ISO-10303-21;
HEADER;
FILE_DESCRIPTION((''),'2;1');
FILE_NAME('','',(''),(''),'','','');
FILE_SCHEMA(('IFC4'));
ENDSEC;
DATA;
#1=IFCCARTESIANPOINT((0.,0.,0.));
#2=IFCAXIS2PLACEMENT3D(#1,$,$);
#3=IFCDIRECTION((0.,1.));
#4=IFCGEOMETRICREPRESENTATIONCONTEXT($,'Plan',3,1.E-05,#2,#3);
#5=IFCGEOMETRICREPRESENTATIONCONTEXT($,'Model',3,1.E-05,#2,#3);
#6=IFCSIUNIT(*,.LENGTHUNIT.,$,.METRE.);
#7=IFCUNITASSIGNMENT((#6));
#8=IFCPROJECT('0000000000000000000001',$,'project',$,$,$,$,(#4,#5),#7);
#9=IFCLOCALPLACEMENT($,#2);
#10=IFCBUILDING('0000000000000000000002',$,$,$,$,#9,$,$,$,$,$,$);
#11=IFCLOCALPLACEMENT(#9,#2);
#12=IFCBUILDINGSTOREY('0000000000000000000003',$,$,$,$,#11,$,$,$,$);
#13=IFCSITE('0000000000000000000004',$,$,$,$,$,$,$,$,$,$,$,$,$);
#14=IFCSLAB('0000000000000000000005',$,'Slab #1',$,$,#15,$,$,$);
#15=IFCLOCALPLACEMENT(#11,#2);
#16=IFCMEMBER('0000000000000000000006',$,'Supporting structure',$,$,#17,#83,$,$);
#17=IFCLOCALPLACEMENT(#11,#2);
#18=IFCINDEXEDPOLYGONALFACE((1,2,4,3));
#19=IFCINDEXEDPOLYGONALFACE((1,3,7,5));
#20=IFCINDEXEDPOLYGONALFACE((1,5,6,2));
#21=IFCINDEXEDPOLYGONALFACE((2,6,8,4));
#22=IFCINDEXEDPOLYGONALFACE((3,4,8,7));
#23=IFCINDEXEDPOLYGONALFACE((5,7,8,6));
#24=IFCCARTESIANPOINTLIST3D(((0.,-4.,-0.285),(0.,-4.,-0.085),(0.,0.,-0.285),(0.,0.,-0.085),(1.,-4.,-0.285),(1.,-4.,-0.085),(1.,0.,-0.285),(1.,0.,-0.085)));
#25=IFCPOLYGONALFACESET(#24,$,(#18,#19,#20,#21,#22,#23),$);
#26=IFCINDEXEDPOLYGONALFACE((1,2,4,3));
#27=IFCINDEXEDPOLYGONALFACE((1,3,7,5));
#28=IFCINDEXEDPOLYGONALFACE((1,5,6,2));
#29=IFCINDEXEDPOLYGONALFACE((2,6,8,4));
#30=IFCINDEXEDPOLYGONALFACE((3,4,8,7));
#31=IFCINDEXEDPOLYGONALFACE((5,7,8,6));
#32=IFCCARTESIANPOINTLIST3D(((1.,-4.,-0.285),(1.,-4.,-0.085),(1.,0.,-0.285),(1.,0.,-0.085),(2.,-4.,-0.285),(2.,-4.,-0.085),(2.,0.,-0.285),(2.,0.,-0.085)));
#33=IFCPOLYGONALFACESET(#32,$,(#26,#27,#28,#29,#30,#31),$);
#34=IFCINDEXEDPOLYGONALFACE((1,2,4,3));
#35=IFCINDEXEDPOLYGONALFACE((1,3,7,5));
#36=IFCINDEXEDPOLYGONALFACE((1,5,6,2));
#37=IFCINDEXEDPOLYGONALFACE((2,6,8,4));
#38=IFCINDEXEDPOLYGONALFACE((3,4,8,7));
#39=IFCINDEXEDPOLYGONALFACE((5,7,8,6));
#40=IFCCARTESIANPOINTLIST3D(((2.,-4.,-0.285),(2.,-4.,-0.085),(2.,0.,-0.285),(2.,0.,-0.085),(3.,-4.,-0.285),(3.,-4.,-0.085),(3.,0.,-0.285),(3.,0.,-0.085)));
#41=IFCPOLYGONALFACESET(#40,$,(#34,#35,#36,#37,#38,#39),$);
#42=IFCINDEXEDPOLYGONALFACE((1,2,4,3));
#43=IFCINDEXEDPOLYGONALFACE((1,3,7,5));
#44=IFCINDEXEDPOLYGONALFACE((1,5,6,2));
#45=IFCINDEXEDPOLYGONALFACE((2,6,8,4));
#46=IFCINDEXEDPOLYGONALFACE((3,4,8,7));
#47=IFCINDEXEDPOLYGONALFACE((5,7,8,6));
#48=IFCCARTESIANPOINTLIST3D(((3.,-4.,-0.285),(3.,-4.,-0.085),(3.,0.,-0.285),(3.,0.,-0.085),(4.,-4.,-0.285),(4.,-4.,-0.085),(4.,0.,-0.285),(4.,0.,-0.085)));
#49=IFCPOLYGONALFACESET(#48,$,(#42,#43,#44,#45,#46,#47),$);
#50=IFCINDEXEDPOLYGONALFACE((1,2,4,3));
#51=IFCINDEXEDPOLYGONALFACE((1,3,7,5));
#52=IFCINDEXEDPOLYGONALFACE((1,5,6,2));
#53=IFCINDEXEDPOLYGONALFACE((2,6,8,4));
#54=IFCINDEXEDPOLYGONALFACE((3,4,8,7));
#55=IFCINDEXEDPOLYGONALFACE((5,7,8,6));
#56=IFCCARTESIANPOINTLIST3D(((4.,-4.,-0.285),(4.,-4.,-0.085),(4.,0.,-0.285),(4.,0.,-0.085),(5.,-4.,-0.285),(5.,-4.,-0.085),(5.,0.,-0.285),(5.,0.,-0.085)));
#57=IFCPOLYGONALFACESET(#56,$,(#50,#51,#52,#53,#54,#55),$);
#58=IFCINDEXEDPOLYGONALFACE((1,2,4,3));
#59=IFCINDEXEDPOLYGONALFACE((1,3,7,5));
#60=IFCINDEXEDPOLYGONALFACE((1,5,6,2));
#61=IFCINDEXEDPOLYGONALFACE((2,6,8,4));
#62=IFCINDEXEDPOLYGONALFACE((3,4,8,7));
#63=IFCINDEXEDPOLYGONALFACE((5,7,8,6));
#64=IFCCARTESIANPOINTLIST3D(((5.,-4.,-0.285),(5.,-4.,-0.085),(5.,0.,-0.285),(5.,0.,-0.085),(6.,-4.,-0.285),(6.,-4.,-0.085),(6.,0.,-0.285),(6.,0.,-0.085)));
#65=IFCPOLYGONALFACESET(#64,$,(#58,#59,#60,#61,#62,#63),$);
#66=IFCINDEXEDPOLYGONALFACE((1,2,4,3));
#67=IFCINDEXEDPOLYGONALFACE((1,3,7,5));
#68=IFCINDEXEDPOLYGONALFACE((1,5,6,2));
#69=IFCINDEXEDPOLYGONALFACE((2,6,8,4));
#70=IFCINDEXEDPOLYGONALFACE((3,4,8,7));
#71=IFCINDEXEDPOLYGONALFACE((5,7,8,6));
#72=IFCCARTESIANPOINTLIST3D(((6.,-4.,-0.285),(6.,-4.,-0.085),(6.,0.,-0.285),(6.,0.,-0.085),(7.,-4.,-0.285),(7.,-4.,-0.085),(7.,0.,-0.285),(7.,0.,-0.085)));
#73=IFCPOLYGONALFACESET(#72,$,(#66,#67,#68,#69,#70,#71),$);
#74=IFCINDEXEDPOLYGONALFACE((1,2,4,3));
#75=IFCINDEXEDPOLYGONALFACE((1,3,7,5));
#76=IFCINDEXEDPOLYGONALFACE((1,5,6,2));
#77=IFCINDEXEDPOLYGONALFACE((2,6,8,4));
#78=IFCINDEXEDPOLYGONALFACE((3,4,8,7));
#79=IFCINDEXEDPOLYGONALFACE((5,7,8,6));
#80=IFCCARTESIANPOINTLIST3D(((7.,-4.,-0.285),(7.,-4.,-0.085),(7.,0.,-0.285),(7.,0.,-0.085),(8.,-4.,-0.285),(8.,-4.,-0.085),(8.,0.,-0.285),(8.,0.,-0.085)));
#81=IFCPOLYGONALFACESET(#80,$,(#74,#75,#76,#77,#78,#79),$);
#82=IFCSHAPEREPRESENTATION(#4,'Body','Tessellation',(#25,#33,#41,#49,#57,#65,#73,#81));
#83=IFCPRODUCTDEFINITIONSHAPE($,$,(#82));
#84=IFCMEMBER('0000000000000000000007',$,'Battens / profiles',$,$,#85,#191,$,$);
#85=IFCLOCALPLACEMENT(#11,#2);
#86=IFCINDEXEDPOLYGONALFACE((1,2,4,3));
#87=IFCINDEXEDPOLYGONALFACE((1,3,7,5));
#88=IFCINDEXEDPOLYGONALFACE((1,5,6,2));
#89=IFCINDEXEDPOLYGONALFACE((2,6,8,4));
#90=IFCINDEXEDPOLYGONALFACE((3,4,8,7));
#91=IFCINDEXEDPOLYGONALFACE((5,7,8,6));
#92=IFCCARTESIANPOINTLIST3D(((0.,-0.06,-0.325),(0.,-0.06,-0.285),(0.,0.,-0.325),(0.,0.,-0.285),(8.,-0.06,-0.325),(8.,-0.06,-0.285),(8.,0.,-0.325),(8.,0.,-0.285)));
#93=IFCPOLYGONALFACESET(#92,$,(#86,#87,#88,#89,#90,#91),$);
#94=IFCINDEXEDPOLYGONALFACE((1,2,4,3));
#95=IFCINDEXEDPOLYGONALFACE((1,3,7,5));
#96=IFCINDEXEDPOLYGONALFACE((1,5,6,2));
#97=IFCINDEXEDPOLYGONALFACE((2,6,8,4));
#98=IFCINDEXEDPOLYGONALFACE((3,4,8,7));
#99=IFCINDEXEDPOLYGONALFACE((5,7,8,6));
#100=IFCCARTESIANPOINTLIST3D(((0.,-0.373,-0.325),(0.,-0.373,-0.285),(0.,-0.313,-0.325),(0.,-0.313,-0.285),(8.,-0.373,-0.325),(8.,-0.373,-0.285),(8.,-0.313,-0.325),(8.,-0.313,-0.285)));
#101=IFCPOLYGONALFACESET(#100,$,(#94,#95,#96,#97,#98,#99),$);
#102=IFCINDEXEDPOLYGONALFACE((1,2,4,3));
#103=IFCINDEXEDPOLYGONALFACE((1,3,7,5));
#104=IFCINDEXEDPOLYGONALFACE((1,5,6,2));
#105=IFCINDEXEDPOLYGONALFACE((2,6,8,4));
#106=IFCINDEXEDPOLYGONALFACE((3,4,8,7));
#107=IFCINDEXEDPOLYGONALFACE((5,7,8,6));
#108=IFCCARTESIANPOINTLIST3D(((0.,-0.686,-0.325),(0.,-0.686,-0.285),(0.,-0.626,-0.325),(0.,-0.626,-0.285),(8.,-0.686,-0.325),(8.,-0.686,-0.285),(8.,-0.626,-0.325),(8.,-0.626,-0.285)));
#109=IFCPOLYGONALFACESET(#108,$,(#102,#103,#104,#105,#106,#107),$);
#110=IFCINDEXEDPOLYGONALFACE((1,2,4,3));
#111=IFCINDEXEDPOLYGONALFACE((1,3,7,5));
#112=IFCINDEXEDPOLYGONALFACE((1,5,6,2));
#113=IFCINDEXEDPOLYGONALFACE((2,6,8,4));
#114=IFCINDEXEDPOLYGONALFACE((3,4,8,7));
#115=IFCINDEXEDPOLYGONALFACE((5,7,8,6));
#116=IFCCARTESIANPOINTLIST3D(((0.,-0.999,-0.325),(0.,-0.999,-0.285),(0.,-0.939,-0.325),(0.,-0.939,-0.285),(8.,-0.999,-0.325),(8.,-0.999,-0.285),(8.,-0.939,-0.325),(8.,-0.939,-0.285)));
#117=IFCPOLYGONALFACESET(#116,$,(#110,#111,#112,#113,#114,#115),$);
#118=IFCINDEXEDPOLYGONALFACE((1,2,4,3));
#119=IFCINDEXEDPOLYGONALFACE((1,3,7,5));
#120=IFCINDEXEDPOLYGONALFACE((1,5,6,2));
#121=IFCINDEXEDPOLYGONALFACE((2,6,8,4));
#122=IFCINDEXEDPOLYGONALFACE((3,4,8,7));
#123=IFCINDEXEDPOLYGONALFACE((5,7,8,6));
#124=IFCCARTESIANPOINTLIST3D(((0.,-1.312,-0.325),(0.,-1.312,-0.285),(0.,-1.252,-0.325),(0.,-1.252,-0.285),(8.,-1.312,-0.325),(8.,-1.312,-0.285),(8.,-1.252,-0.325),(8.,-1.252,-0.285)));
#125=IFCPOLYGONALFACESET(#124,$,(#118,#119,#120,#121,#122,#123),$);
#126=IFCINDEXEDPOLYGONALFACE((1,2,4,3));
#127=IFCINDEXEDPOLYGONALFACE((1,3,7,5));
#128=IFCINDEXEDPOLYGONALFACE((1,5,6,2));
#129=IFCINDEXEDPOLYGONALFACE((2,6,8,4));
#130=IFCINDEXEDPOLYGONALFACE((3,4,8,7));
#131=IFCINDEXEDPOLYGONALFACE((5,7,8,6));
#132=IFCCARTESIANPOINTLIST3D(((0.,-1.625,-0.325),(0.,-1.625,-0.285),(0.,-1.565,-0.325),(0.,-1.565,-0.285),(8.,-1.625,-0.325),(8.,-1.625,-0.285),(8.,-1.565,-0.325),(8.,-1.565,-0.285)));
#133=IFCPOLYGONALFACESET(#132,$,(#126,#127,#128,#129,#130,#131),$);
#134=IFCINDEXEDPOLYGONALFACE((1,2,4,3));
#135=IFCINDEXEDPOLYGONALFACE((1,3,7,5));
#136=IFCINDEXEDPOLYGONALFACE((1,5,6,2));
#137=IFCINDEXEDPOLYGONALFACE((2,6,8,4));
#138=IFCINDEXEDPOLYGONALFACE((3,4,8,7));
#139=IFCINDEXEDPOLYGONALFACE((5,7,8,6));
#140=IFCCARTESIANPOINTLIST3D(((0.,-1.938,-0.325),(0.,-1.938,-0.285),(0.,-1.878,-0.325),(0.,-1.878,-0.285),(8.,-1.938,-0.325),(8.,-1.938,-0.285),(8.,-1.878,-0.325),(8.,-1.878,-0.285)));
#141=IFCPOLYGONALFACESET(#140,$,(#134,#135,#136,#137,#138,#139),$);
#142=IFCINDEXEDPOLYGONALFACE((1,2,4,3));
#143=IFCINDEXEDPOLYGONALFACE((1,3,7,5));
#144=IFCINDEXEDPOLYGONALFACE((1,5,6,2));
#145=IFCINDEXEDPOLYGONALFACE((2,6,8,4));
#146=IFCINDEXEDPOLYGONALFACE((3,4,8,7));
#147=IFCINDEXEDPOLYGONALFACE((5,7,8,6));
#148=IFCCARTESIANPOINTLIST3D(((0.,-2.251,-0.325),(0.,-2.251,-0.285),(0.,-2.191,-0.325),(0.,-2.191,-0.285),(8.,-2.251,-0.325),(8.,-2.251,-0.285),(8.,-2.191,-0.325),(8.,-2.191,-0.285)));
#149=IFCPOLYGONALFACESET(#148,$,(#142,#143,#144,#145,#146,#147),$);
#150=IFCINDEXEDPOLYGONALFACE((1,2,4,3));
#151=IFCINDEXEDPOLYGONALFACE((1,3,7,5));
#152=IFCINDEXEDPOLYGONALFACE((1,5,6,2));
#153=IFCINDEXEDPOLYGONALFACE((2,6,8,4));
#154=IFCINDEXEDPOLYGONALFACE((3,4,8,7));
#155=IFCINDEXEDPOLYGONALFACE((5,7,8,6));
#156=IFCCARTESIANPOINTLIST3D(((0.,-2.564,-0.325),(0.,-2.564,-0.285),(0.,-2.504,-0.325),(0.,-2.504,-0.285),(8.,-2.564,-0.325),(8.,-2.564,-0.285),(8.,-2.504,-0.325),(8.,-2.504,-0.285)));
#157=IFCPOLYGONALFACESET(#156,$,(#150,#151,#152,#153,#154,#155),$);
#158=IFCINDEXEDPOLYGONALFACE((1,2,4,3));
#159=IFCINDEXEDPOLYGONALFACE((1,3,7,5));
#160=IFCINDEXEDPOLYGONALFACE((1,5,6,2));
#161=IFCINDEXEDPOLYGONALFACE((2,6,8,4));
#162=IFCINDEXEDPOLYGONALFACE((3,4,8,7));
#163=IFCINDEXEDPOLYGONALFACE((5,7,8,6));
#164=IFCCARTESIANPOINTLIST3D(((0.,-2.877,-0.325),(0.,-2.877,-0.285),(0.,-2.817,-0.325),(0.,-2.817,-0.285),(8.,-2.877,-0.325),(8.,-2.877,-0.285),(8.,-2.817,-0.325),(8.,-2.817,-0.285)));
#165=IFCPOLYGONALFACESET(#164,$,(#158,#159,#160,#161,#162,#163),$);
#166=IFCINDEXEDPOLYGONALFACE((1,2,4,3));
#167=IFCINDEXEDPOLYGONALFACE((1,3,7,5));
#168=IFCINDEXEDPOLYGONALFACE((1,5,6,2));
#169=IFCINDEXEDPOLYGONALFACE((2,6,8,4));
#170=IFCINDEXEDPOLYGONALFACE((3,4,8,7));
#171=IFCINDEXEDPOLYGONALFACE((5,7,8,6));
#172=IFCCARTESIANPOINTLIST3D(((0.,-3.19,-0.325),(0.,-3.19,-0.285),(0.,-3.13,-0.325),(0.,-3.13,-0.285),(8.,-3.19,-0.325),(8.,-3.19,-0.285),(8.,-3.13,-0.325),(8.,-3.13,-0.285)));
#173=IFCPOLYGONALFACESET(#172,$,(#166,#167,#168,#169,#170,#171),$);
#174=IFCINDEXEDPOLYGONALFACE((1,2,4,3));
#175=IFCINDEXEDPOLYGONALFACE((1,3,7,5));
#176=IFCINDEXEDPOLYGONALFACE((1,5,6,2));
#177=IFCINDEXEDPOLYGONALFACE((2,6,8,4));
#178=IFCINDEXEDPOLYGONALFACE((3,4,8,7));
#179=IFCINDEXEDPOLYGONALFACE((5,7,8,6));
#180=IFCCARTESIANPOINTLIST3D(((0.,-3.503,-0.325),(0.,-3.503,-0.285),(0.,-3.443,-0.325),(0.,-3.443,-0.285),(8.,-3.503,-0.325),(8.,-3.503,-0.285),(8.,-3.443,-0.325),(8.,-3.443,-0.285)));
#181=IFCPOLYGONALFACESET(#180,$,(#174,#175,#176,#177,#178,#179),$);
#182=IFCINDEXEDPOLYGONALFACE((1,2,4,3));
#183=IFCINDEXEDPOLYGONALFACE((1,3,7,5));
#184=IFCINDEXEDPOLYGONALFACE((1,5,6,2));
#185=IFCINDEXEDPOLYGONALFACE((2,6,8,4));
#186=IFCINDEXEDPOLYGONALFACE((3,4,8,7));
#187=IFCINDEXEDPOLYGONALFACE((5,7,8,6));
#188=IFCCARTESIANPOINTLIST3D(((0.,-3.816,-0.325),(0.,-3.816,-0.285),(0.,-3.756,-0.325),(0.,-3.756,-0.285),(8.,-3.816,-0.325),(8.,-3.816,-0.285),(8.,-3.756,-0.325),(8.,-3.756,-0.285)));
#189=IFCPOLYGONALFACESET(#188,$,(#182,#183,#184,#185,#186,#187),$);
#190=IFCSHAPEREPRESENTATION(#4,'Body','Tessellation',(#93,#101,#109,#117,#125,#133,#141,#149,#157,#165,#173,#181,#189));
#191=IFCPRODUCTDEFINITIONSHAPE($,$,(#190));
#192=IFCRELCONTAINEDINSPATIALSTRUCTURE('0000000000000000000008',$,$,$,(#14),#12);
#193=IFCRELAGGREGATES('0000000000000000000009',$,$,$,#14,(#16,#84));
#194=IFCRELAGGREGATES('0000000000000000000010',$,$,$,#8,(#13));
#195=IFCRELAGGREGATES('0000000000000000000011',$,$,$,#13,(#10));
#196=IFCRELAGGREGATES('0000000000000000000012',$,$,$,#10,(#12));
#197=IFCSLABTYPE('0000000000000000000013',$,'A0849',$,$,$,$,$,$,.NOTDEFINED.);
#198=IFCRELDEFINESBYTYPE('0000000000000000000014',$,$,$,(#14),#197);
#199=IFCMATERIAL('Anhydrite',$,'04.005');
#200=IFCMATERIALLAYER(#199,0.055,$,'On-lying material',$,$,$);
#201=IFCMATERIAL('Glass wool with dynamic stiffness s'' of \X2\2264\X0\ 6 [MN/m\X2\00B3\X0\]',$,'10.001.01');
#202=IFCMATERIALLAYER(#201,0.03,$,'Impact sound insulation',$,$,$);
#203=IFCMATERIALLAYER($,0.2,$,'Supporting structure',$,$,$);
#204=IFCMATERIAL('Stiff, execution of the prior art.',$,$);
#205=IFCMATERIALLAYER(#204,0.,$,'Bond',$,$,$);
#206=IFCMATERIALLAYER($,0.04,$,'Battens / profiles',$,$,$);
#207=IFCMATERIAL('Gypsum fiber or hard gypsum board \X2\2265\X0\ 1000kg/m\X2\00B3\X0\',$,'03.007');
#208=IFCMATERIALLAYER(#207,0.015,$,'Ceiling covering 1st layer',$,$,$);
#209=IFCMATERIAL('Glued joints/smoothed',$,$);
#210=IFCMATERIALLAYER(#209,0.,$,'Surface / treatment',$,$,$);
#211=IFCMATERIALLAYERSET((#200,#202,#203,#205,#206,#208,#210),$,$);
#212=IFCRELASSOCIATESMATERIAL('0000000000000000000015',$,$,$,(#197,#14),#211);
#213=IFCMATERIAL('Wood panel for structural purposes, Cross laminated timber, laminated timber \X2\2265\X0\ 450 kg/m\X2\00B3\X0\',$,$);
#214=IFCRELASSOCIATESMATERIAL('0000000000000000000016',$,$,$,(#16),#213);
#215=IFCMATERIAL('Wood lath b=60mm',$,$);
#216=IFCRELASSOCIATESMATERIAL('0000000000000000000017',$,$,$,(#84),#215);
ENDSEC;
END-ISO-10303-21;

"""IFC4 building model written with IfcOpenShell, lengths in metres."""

from ifc_helpers import new_model, si_unit, direction, frame, frame_2d, origin, place, context, project, spatial, rectangle, extrude, material, layer, layer_set, type_object, element, aggregate, save


model = new_model("IFC4")

# Units and contexts
plan_context = context("Plan", 3, precision=1e-05, world=origin(), true_north=direction((0.0, 1.0)))
model_context = context("Model", 3, precision=1e-05, world=origin(), true_north=direction((0.0, 1.0)))
ifc_project = project(units=[si_unit("LENGTHUNIT", "METRE")], contexts=[plan_context, model_context])

# Site, building, storey
site = spatial("IfcSite", under=ifc_project)
building_placement = place(None, origin())
building = spatial("IfcBuilding", under=site, at=building_placement)
storey_placement = place(building_placement, origin())
storey = spatial("IfcBuildingStorey", under=building, at=storey_placement)

# Slab, members
ifc_material_1 = material(Name="Anhydrite", Category="04.005")
ifc_layer_1 = layer(ifc_material_1, 0.055, Name="On-lying material")
ifc_material_2 = material(Name="Glass wool with dynamic stiffness s' of ≤ 6 [MN/m³]", Category="10.001.01")
ifc_layer_2 = layer(ifc_material_2, 0.03, Name="Impact sound insulation")
ifc_layer_3 = layer(None, 0.2, Name="Supporting structure")
ifc_material_3 = material(Name="Stiff, execution of the prior art.")
ifc_layer_4 = layer(ifc_material_3, 0.0, Name="Bond")
ifc_layer_5 = layer(None, 0.04, Name="Battens / profiles")
ifc_material_4 = material(Name="Gypsum fiber or hard gypsum board ≥ 1000kg/m³", Category="03.007")
ifc_layer_6 = layer(ifc_material_4, 0.015, Name="Ceiling covering 1st layer")
ifc_material_5 = material(Name="Glued joints/smoothed")
ifc_layer_7 = layer(ifc_material_5, 0.0, Name="Surface / treatment")
ifc_layer_set = layer_set([ifc_layer_1, ifc_layer_2, ifc_layer_3, ifc_layer_4, ifc_layer_5, ifc_layer_6, ifc_layer_7])
slab_type = type_object("IfcSlabType", Name="A0849", PredefinedType="NOTDEFINED", material=ifc_layer_set)
slab_placement = place(None, frame((0.0, 0.0, 0.0), z_axis=(0.0, 0.0, -1.0), x_axis=(1.0, 0.0, 0.0)))
slab = element("IfcSlab", 1, at=slab_placement, inside=storey, type_object=slab_type, material=ifc_layer_set, Name="Slab #1")
ifc_material_6 = material(Name="Wood panel for structural purposes, Cross laminated timber, laminated timber ≥ 450 kg/m³")
member_1_placement = place(slab_placement, origin())
member_1 = element("IfcMember", 2, at=member_1_placement, material=ifc_material_6, Name="Supporting structure", context=plan_context, shape_type="SweptSolid", body=[
    extrude(rectangle(XDim=1.0, YDim=0.2, at=frame_2d((0.5, 0.1), x_axis=(1.0, 0.0))), frame((0.0, 4.0, 0.085), z_axis=(0.0, -1.0, 0.0), x_axis=(1.0, 0.0, 0.0)), (0.0, 0.0, 1.0), 4.0),
    extrude(rectangle(XDim=1.0, YDim=0.2, at=frame_2d((0.5, 0.1), x_axis=(1.0, 0.0))), frame((1.0, 4.0, 0.085), z_axis=(0.0, -1.0, 0.0), x_axis=(1.0, 0.0, 0.0)), (0.0, 0.0, 1.0), 4.0),
    extrude(rectangle(XDim=1.0, YDim=0.2, at=frame_2d((0.5, 0.1), x_axis=(1.0, 0.0))), frame((2.0, 4.0, 0.085), z_axis=(0.0, -1.0, 0.0), x_axis=(1.0, 0.0, 0.0)), (0.0, 0.0, 1.0), 4.0),
    extrude(rectangle(XDim=1.0, YDim=0.2, at=frame_2d((0.5, 0.1), x_axis=(1.0, 0.0))), frame((3.0, 4.0, 0.085), z_axis=(0.0, -1.0, 0.0), x_axis=(1.0, 0.0, 0.0)), (0.0, 0.0, 1.0), 4.0),
    extrude(rectangle(XDim=1.0, YDim=0.2, at=frame_2d((0.5, 0.1), x_axis=(1.0, 0.0))), frame((4.0, 4.0, 0.085), z_axis=(0.0, -1.0, 0.0), x_axis=(1.0, 0.0, 0.0)), (0.0, 0.0, 1.0), 4.0),
    extrude(rectangle(XDim=1.0, YDim=0.2, at=frame_2d((0.5, 0.1), x_axis=(1.0, 0.0))), frame((5.0, 4.0, 0.085), z_axis=(0.0, -1.0, 0.0), x_axis=(1.0, 0.0, 0.0)), (0.0, 0.0, 1.0), 4.0),
    extrude(rectangle(XDim=1.0, YDim=0.2, at=frame_2d((0.5, 0.1), x_axis=(1.0, 0.0))), frame((6.0, 4.0, 0.085), z_axis=(0.0, -1.0, 0.0), x_axis=(1.0, 0.0, 0.0)), (0.0, 0.0, 1.0), 4.0),
    extrude(rectangle(XDim=1.0, YDim=0.2, at=frame_2d((0.5, 0.1), x_axis=(1.0, 0.0))), frame((7.0, 4.0, 0.085), z_axis=(0.0, -1.0, 0.0), x_axis=(1.0, 0.0, 0.0)), (0.0, 0.0, 1.0), 4.0),
])
ifc_material_7 = material(Name="Wood lath b=60mm")
member_2_placement = place(slab_placement, origin())
member_2 = element("IfcMember", 3, at=member_2_placement, material=ifc_material_7, Name="Battens / profiles", context=plan_context, shape_type="SweptSolid", body=[
    extrude(rectangle(XDim=0.06, YDim=0.04, at=frame_2d((0.03, 0.02), x_axis=(1.0, 0.0))), frame((0.0, 0.0, 0.285), z_axis=(1.0, 0.0, 0.0), x_axis=(0.0, 1.0, 0.0)), (0.0, 0.0, 1.0), 8.0),
    extrude(rectangle(XDim=0.06, YDim=0.04, at=frame_2d((0.03, 0.02), x_axis=(1.0, 0.0))), frame((0.0, 0.313, 0.285), z_axis=(1.0, 0.0, 0.0), x_axis=(0.0, 1.0, 0.0)), (0.0, 0.0, 1.0), 8.0),
    extrude(rectangle(XDim=0.06, YDim=0.04, at=frame_2d((0.03, 0.02), x_axis=(1.0, 0.0))), frame((0.0, 0.626, 0.285), z_axis=(1.0, 0.0, 0.0), x_axis=(0.0, 1.0, 0.0)), (0.0, 0.0, 1.0), 8.0),
    extrude(rectangle(XDim=0.06, YDim=0.04, at=frame_2d((0.03, 0.02), x_axis=(1.0, 0.0))), frame((0.0, 0.939, 0.285), z_axis=(1.0, 0.0, 0.0), x_axis=(0.0, 1.0, 0.0)), (0.0, 0.0, 1.0), 8.0),
    extrude(rectangle(XDim=0.06, YDim=0.04, at=frame_2d((0.03, 0.02), x_axis=(1.0, 0.0))), frame((0.0, 1.252, 0.285), z_axis=(1.0, 0.0, 0.0), x_axis=(0.0, 1.0, 0.0)), (0.0, 0.0, 1.0), 8.0),
    extrude(rectangle(XDim=0.06, YDim=0.04, at=frame_2d((0.03, 0.02), x_axis=(1.0, 0.0))), frame((0.0, 1.565, 0.285), z_axis=(1.0, 0.0, 0.0), x_axis=(0.0, 1.0, 0.0)), (0.0, 0.0, 1.0), 8.0),
    extrude(rectangle(XDim=0.06, YDim=0.04, at=frame_2d((0.03, 0.02), x_axis=(1.0, 0.0))), frame((0.0, 1.878, 0.285), z_axis=(1.0, 0.0, 0.0), x_axis=(0.0, 1.0, 0.0)), (0.0, 0.0, 1.0), 8.0),
    extrude(rectangle(XDim=0.06, YDim=0.04, at=frame_2d((0.03, 0.02), x_axis=(1.0, 0.0))), frame((0.0, 2.191, 0.285), z_axis=(1.0, 0.0, 0.0), x_axis=(0.0, 1.0, 0.0)), (0.0, 0.0, 1.0), 8.0),
    extrude(rectangle(XDim=0.06, YDim=0.04, at=frame_2d((0.03, 0.02), x_axis=(1.0, 0.0))), frame((0.0, 2.504, 0.285), z_axis=(1.0, 0.0, 0.0), x_axis=(0.0, 1.0, 0.0)), (0.0, 0.0, 1.0), 8.0),
    extrude(rectangle(XDim=0.06, YDim=0.04, at=frame_2d((0.03, 0.02), x_axis=(1.0, 0.0))), frame((0.0, 2.817, 0.285), z_axis=(1.0, 0.0, 0.0), x_axis=(0.0, 1.0, 0.0)), (0.0, 0.0, 1.0), 8.0),
    extrude(rectangle(XDim=0.06, YDim=0.04, at=frame_2d((0.03, 0.02), x_axis=(1.0, 0.0))), frame((0.0, 3.13, 0.285), z_axis=(1.0, 0.0, 0.0), x_axis=(0.0, 1.0, 0.0)), (0.0, 0.0, 1.0), 8.0),
    extrude(rectangle(XDim=0.06, YDim=0.04, at=frame_2d((0.03, 0.02), x_axis=(1.0, 0.0))), frame((0.0, 3.443, 0.285), z_axis=(1.0, 0.0, 0.0), x_axis=(0.0, 1.0, 0.0)), (0.0, 0.0, 1.0), 8.0),
    extrude(rectangle(XDim=0.06, YDim=0.04, at=frame_2d((0.03, 0.02), x_axis=(1.0, 0.0))), frame((0.0, 3.756, 0.285), z_axis=(1.0, 0.0, 0.0), x_axis=(0.0, 1.0, 0.0)), (0.0, 0.0, 1.0), 8.0),
])
aggregate(slab, [member_1, member_2])

save(model, "model.ifc")
